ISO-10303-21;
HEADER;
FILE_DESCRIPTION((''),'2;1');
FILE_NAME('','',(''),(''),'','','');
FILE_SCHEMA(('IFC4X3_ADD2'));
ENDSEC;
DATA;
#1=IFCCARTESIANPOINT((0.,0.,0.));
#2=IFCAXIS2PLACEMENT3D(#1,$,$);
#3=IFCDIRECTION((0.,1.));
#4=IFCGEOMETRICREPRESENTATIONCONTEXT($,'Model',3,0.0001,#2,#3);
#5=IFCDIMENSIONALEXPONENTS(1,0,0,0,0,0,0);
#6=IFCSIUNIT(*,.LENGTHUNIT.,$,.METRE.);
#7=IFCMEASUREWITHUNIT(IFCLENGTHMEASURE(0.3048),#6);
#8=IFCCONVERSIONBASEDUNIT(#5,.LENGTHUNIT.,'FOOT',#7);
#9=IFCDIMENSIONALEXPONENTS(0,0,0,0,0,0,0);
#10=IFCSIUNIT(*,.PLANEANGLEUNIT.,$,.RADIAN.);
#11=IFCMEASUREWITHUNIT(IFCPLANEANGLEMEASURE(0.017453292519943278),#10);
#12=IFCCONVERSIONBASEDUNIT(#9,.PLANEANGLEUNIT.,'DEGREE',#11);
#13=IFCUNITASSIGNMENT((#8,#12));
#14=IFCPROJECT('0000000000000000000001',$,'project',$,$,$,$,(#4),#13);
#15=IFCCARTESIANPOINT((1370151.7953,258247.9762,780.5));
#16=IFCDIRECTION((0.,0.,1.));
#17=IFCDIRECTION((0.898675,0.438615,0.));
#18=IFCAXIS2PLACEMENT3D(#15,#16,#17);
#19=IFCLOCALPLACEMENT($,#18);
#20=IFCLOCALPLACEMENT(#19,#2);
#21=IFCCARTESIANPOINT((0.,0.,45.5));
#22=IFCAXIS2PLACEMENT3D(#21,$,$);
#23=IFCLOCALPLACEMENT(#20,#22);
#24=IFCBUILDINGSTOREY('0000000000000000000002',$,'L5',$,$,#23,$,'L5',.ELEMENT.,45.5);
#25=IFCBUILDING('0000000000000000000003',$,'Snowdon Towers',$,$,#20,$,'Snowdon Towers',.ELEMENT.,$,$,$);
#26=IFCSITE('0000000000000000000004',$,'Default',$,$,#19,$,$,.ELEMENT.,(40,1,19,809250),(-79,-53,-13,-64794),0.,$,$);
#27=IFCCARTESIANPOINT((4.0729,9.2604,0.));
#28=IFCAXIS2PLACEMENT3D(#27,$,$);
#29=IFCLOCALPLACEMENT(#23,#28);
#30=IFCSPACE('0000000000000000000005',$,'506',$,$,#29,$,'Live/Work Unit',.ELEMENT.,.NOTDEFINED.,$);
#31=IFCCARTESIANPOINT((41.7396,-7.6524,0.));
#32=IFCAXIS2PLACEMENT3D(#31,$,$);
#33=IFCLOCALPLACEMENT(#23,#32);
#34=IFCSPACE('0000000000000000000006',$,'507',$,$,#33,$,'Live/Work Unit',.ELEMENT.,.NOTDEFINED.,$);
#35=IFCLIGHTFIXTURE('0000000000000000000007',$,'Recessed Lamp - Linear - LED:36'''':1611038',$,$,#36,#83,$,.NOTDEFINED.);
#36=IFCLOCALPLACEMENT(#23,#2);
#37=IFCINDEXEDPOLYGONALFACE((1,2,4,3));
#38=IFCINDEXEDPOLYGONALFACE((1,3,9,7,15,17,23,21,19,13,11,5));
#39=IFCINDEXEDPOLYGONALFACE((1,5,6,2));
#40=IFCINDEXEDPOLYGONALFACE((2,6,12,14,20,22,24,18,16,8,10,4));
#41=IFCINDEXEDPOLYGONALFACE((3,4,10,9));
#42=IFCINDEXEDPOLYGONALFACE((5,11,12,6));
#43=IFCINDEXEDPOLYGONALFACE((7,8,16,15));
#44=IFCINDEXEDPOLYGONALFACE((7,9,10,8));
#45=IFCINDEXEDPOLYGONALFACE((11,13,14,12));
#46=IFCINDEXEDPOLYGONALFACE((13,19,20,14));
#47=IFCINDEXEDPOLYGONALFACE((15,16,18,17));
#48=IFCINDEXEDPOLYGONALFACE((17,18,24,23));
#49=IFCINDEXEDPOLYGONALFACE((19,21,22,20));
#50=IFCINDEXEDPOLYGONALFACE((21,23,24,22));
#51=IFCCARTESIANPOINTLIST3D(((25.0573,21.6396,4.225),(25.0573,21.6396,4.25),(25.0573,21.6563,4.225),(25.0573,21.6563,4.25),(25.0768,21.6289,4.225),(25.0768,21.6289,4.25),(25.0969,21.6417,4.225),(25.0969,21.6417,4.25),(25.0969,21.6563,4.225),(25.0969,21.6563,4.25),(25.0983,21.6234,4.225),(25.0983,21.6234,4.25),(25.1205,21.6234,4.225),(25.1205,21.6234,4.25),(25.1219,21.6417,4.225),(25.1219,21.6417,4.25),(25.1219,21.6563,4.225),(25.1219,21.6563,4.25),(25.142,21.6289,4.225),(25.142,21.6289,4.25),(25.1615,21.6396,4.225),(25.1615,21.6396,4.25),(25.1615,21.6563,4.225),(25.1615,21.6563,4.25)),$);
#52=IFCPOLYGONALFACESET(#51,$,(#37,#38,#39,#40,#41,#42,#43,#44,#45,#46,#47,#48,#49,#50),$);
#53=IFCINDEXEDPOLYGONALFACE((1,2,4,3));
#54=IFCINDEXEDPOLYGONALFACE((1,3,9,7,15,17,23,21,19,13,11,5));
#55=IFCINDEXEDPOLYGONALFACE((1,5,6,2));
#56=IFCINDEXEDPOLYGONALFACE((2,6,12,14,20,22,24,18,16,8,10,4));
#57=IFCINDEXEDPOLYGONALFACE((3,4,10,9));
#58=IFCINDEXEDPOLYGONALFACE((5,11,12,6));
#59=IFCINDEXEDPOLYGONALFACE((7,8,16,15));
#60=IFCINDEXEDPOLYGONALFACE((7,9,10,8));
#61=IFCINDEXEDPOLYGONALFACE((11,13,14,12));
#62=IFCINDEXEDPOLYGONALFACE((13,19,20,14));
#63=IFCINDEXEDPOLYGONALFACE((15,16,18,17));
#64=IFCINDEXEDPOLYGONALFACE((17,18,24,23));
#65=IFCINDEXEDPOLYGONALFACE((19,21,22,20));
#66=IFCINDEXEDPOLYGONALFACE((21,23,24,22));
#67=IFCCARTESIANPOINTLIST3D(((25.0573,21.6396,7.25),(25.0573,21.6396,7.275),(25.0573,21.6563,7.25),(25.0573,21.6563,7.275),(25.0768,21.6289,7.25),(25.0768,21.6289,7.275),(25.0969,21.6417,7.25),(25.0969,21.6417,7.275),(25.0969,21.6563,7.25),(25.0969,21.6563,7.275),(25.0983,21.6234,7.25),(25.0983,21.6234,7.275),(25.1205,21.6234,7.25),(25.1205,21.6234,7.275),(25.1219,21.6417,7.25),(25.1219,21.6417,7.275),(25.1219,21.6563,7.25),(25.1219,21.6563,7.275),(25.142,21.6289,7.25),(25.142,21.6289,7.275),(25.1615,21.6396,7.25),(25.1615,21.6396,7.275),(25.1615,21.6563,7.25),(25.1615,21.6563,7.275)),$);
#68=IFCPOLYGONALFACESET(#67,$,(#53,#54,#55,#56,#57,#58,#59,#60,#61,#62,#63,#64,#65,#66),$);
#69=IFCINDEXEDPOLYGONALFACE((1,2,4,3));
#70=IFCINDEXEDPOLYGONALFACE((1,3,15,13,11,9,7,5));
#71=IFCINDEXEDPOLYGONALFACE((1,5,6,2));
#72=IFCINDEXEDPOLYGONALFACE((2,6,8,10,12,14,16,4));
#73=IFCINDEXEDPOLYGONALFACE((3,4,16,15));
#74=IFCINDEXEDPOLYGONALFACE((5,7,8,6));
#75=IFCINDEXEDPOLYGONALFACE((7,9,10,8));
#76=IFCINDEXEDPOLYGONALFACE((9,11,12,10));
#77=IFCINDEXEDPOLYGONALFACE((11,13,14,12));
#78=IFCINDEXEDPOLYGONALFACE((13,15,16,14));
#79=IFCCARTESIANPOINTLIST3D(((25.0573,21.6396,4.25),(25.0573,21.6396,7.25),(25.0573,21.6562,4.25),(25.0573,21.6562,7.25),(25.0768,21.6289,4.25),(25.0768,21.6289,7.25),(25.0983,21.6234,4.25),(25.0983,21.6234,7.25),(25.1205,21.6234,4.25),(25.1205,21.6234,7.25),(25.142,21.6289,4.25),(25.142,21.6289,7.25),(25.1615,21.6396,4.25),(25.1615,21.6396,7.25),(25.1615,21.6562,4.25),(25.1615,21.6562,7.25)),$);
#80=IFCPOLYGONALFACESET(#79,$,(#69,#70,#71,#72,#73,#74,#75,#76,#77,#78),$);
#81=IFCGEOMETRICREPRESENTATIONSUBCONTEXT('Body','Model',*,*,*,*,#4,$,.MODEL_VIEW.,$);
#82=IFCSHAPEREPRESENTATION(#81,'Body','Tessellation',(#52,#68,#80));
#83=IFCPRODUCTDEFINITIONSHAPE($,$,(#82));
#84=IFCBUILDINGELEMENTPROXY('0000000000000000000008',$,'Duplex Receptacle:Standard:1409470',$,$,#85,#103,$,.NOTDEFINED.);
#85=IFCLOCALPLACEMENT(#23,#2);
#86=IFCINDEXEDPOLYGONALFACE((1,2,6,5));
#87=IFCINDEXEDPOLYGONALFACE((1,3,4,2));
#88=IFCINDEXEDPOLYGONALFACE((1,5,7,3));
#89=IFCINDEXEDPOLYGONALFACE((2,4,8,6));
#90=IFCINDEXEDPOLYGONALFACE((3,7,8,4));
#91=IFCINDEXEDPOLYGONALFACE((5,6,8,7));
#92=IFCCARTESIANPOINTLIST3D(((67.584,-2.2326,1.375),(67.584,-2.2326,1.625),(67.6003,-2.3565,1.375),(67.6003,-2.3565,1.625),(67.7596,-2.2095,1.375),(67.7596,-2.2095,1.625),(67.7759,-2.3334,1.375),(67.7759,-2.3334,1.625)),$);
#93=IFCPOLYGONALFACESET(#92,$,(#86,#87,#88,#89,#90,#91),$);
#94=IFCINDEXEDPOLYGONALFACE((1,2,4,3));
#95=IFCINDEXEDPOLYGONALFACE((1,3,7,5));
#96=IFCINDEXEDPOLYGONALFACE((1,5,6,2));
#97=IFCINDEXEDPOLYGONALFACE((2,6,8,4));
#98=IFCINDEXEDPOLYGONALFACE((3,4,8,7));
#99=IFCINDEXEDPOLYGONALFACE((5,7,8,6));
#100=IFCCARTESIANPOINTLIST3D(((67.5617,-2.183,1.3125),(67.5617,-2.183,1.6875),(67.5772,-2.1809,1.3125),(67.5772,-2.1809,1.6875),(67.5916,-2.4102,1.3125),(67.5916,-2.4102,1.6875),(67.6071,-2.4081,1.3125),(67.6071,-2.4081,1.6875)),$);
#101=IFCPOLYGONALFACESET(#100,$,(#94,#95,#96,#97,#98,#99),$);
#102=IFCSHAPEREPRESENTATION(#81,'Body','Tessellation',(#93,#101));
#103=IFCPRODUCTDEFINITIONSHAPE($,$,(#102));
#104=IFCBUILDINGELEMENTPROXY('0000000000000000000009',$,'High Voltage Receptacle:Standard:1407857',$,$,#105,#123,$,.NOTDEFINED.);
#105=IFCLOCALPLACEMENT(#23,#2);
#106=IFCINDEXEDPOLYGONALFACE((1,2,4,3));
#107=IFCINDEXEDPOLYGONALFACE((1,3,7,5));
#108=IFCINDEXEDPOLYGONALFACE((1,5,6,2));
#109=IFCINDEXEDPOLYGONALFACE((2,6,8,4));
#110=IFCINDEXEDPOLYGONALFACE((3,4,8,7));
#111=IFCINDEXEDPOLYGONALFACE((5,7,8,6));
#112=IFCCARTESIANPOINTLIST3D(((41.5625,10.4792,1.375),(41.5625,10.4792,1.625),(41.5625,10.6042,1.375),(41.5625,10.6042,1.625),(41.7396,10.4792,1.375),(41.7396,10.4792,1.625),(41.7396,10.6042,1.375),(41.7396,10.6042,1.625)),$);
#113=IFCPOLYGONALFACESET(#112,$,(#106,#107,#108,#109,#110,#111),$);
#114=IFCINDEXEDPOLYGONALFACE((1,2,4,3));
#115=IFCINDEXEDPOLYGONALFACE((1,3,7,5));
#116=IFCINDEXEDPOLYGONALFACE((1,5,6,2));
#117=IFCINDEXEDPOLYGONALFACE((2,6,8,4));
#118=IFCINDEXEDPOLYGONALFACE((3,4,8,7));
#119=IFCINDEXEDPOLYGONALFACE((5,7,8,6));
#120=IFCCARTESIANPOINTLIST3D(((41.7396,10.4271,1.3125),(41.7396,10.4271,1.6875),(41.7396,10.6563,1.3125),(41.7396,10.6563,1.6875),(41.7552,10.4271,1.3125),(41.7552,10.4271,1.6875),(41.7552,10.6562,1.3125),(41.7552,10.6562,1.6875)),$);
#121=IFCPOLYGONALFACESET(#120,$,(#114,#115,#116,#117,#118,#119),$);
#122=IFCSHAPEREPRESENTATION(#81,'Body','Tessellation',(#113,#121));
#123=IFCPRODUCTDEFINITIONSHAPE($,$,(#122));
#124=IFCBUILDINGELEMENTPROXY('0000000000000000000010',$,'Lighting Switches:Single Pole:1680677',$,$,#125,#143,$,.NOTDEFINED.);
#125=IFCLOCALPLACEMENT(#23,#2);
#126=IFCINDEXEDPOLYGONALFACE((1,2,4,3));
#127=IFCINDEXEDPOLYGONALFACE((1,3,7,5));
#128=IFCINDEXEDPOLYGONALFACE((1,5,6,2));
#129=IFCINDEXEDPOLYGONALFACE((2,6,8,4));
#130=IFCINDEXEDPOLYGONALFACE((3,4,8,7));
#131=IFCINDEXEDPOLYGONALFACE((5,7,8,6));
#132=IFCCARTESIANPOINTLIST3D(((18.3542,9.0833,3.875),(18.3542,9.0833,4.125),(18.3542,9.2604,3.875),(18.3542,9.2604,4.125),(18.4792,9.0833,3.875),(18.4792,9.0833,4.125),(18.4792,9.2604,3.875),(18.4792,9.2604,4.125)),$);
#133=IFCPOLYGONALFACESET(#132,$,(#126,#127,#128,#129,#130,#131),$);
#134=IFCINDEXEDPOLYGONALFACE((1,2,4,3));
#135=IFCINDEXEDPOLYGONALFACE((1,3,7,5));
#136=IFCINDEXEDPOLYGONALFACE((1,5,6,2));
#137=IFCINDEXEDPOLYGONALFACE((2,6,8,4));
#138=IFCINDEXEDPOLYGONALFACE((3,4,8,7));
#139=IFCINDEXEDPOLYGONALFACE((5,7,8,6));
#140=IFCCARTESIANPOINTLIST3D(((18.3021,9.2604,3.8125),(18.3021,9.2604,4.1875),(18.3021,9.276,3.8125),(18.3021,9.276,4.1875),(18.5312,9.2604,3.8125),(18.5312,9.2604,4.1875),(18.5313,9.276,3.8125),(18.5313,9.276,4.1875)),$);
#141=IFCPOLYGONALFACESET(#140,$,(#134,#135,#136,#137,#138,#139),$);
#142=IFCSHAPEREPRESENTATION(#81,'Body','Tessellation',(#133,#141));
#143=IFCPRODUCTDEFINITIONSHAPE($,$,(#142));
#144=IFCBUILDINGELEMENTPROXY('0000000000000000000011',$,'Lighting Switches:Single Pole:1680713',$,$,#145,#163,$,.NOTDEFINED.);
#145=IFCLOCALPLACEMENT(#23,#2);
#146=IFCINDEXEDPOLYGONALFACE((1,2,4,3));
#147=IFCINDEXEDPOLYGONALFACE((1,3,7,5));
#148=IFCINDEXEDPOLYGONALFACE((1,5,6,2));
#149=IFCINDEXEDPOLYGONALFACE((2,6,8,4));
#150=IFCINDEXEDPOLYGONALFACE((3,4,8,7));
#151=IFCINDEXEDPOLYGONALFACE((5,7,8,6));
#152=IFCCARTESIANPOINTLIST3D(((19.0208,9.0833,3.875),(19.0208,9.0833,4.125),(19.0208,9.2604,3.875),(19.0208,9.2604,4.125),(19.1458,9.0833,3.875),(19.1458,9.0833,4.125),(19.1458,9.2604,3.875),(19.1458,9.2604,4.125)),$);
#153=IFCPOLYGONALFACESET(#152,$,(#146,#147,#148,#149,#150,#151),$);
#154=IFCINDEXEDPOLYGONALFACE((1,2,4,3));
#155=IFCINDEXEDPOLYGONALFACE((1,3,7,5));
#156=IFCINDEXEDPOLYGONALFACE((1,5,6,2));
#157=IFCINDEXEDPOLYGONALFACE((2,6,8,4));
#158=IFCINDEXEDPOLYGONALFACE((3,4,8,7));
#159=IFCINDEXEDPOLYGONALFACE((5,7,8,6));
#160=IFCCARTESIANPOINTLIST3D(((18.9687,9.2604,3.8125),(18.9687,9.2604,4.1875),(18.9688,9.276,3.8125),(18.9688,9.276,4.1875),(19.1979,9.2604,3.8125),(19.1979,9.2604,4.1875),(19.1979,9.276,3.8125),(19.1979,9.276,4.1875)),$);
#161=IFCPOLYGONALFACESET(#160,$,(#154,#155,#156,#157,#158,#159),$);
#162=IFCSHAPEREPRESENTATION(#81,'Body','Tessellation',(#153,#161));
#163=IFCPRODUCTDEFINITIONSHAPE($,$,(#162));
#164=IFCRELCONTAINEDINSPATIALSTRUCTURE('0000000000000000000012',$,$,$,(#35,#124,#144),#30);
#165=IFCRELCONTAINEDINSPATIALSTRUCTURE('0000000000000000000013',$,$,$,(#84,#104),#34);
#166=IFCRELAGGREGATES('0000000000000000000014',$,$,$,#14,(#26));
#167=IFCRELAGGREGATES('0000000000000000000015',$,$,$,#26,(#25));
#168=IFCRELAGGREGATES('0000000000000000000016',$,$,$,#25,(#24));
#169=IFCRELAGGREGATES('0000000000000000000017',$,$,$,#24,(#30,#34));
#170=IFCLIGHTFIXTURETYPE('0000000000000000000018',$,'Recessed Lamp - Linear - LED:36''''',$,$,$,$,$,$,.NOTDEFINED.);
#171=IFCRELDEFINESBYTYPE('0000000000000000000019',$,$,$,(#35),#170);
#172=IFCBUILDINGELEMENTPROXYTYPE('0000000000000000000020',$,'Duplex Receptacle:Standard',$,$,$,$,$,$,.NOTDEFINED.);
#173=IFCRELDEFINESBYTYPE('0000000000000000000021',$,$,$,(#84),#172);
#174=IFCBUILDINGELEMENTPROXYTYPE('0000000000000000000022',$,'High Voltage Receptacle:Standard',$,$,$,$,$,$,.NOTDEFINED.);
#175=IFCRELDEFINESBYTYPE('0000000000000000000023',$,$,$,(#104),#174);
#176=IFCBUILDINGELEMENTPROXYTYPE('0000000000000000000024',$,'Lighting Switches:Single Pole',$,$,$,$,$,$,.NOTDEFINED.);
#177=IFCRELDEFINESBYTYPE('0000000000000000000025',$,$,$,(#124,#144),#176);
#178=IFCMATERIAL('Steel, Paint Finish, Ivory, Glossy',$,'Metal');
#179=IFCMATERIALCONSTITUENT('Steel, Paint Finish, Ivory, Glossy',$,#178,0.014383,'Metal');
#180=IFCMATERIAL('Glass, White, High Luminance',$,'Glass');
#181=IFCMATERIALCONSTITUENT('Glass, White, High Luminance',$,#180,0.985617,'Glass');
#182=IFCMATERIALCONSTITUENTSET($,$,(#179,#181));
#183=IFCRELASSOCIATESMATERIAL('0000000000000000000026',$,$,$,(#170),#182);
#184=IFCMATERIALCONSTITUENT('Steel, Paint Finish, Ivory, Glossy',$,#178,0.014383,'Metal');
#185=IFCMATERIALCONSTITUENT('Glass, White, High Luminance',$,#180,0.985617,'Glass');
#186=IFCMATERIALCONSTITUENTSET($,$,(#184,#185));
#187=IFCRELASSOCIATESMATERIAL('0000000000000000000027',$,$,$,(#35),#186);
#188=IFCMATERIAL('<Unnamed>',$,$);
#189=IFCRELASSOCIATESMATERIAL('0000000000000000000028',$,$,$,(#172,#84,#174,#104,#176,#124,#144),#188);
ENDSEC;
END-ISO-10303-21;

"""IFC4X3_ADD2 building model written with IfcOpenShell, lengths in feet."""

from ifc_helpers import new_model, entity, si_unit, converted_unit, direction, frame, frame_2d, origin, origin_2d_with_axis, place, context, subcontext, project, spatial, polyline, circle_curve, parameter, trimmed, segment, composite_curve, rectangle, outline, extrude, source, transform, mapped, material, constituent, constituent_set, type_object, type_shapes, element, save


model = new_model("IFC4X3_ADD2")

# Units and contexts
model_context = context("Model", 3, precision=0.0001, world=origin(), true_north=direction((0.0, 1.0)))
body_context = subcontext(model_context, "Body", "Model", "MODEL_VIEW")
ifc_project = project(units=[converted_unit("LENGTHUNIT", "FOOT", entity("IfcLengthMeasure", 0.3048), si_unit("LENGTHUNIT", "METRE"), dimensions=[1, 0, 0, 0, 0, 0, 0]), converted_unit("PLANEANGLEUNIT", "DEGREE", entity("IfcPlaneAngleMeasure", 0.017453292519943278), si_unit("PLANEANGLEUNIT", "RADIAN"), dimensions=[0, 0, 0, 0, 0, 0, 0])], contexts=[model_context])

# Site, building, storey, space
site_placement = place(None, frame((1370151.7953, 258247.9762, 780.5), z_axis=(0.0, 0.0, 1.0), x_axis=(0.898675, 0.438615, 0.0)))
site = spatial("IfcSite", under=ifc_project, at=site_placement, Name="Default", CompositionType="ELEMENT", RefLatitude=(40, 1, 19, 809250), RefLongitude=(-79, -53, -13, -64794), RefElevation=0.0)
building_placement = place(site_placement, origin())
building = spatial("IfcBuilding", under=site, at=building_placement, Name="Snowdon Towers", LongName="Snowdon Towers", CompositionType="ELEMENT")
storey_placement = place(building_placement, frame((0.0, 0.0, 45.5)))
storey = spatial("IfcBuildingStorey", under=building, at=storey_placement, Name="L5", LongName="L5", CompositionType="ELEMENT", Elevation=45.5)
space_1_placement = place(storey_placement, frame((4.0729, 9.2604, 0.0)))
space_1 = spatial("IfcSpace", under=storey, at=space_1_placement, Name="506", LongName="Live/Work Unit", CompositionType="ELEMENT", PredefinedType="NOTDEFINED")

# Shared definitions
ifc_material_1 = material(Name="<Unnamed>")

# Shared definitions
ifc_material_2 = material(Name="Glass, White, High Luminance", Category="Glass")
ifc_material_3 = material(Name="Steel, Paint Finish, Ivory, Glossy", Category="Metal")
ifc_constituent_1 = constituent(ifc_material_3, Name="Steel, Paint Finish, Ivory, Glossy", Category="Metal", fraction=0.014383)
ifc_constituent_2 = constituent(ifc_material_2, Name="Glass, White, High Luminance", Category="Glass", fraction=0.985617)
ifc_constituent_set_1 = constituent_set(constituents=[ifc_constituent_1, ifc_constituent_2])
light_fixture_type_1 = type_object("IfcLightFixtureType", Name="Recessed Lamp - Linear - LED:36''", PredefinedType="NOTDEFINED", material=ifc_constituent_set_1)
shared_shape_1 = source(origin(), body_context, "Body", "SweptSolid", [
    extrude(outline(composite_curve([segment(trimmed(circle_curve(frame_2d((0.0, -0.0633), x_axis=(1.0, 0.0)), 0.089), [parameter(54.196986)], [parameter(125.803014)], True, "PARAMETER"), True, "CONTINUOUS"), segment(polyline([(-0.0521, 0.0089), (-0.0521, -0.0078)]), True, "CONTINUOUS"), segment(polyline([(-0.0521, -0.0078), (-0.0125, -0.0078)]), True, "CONTINUOUS"), segment(polyline([(-0.0125, -0.0078), (-0.0125, 0.0068)]), True, "CONTINUOUS"), segment(polyline([(-0.0125, 0.0068), (0.0125, 0.0068)]), True, "CONTINUOUS"), segment(polyline([(0.0125, 0.0068), (0.0125, -0.0078)]), True, "CONTINUOUS"), segment(polyline([(0.0125, -0.0078), (0.0521, -0.0078)]), True, "CONTINUOUS"), segment(polyline([(0.0521, -0.0078), (0.0521, 0.0089)]), True, "CONTINUOUS")], self_intersect=False)), frame((-1.525, 0.0, 0.0078), z_axis=(1.0, 0.0, 0.0), x_axis=(0.0, 1.0, 0.0)), (0.0, 0.0, 1.0), 0.025),
    extrude(outline(composite_curve([segment(trimmed(circle_curve(frame_2d((0.0, -0.0633), x_axis=(1.0, 0.0)), 0.089), [parameter(54.196986)], [parameter(125.803014)], True, "PARAMETER"), True, "CONTINUOUS"), segment(polyline([(-0.0521, 0.0089), (-0.0521, -0.0078)]), True, "CONTINUOUS"), segment(polyline([(-0.0521, -0.0078), (-0.0125, -0.0078)]), True, "CONTINUOUS"), segment(polyline([(-0.0125, -0.0078), (-0.0125, 0.0068)]), True, "CONTINUOUS"), segment(polyline([(-0.0125, 0.0068), (0.0125, 0.0068)]), True, "CONTINUOUS"), segment(polyline([(0.0125, 0.0068), (0.0125, -0.0078)]), True, "CONTINUOUS"), segment(polyline([(0.0125, -0.0078), (0.0521, -0.0078)]), True, "CONTINUOUS"), segment(polyline([(0.0521, -0.0078), (0.0521, 0.0089)]), True, "CONTINUOUS")], self_intersect=False)), frame((1.5, 0.0, 0.0078), z_axis=(1.0, 0.0, 0.0), x_axis=(0.0, 1.0, 0.0)), (0.0, 0.0, 1.0), 0.025),
    extrude(outline(composite_curve([segment(trimmed(circle_curve(frame_2d((0.0, -0.0639), x_axis=(1.0, 0.0)), 0.089), [parameter(54.196986)], [parameter(125.803014)], True, "PARAMETER"), True, "CONTINUOUS"), segment(polyline([(-0.0521, 0.0083), (-0.0521, -0.0083)]), True, "CONTINUOUS"), segment(polyline([(-0.0521, -0.0083), (0.0521, -0.0083)]), True, "CONTINUOUS"), segment(polyline([(0.0521, -0.0083), (0.0521, 0.0083)]), True, "CONTINUOUS")], self_intersect=False)), frame((-1.5, 0.0, 0.0083), z_axis=(1.0, 0.0, 0.0), x_axis=(0.0, 1.0, 0.0)), (0.0, 0.0, 1.0), 3.0),
])
type_shapes(light_fixture_type_1, [shared_shape_1])

# Shared definitions
space_2_placement = place(storey_placement, frame((41.7396, -7.6524, 0.0)))
space_2 = spatial("IfcSpace", under=storey, at=space_2_placement, Name="507", LongName="Live/Work Unit", CompositionType="ELEMENT", PredefinedType="NOTDEFINED")

# Light fixture
ifc_constituent_3 = constituent(ifc_material_3, Name="Steel, Paint Finish, Ivory, Glossy", Category="Metal", fraction=0.014383)
ifc_constituent_4 = constituent(ifc_material_2, Name="Glass, White, High Luminance", Category="Glass", fraction=0.985617)
ifc_constituent_set_2 = constituent_set(constituents=[ifc_constituent_3, ifc_constituent_4])
light_fixture_1_placement = place(space_1_placement, frame((21.0365, 12.3958, 5.75), z_axis=(0.0, -1.0, 0.0), x_axis=(0.0, 0.0, 1.0)))
element("IfcLightFixture", 1, at=light_fixture_1_placement, inside=space_1, type_object=light_fixture_type_1, material=ifc_constituent_set_2, Name="Recessed Lamp - Linear - LED:36'':1611038", PredefinedType="NOTDEFINED", context=body_context, shape_type="MappedRepresentation", body=[
    mapped(shared_shape_1, transform((0.0, 0.0, 0.0), scale=1.0)),
])

# Building element proxy
building_element_proxy_type_1 = type_object("IfcBuildingElementProxyType", Name="Duplex Receptacle:Standard", PredefinedType="NOTDEFINED", material=ifc_material_1)
shared_shape_2 = source(origin(), body_context, "Body", "SweptSolid", [
    extrude(rectangle(XDim=0.125, YDim=0.25, at=origin_2d_with_axis()), frame((0.0, 0.0, -0.1771), z_axis=(0.0, 0.0, 1.0), x_axis=(-1.0, 0.0, 0.0)), (0.0, 0.0, 1.0), 0.1771),
    extrude(rectangle(XDim=0.2292, YDim=0.375, at=frame_2d((0.0, 0.0), x_axis=(1.0, 0.0))), frame((0.0, 0.0, 0.0), z_axis=(0.0, 0.0, 1.0), x_axis=(-1.0, 0.0, 0.0)), (0.0, 0.0, 1.0), 0.0156),
])
type_shapes(building_element_proxy_type_1, [shared_shape_2])
for number, where, z_axis, x_axis, name in (
    (2, (25.8526, 5.3578, 1.5), (-0.991445, -0.130526, 0.0), (0.130526, -0.991445, 0.0), "Duplex Receptacle:Standard:1409470"),
):
    element("IfcBuildingElementProxy", number, at=place(space_2_placement, frame(where, z_axis=z_axis, x_axis=x_axis)), inside=space_2, type_object=building_element_proxy_type_1, material=ifc_material_1, Name=name, PredefinedType="NOTDEFINED", context=body_context, shape_type="MappedRepresentation", body=[
        mapped(shared_shape_2, transform((0.0, 0.0, 0.0), scale=1.0)),
    ])

# Building element proxies
building_element_proxy_type_2 = type_object("IfcBuildingElementProxyType", Name="High Voltage Receptacle:Standard", PredefinedType="NOTDEFINED", material=ifc_material_1)
shared_shape_3 = source(origin(), body_context, "Body", "SweptSolid", [
    extrude(rectangle(XDim=0.125, YDim=0.25, at=origin_2d_with_axis()), frame((0.0, 0.0, -0.1771), z_axis=(0.0, 0.0, 1.0), x_axis=(-1.0, 0.0, 0.0)), (0.0, 0.0, 1.0), 0.1771),
    extrude(rectangle(XDim=0.2292, YDim=0.375, at=frame_2d((0.0, 0.0), x_axis=(1.0, 0.0))), frame((0.0, 0.0, 0.0), z_axis=(0.0, 0.0, 1.0), x_axis=(-1.0, 0.0, 0.0)), (0.0, 0.0, 1.0), 0.0156),
])
type_shapes(building_element_proxy_type_2, [shared_shape_3])
proxy_1_placement = place(space_2_placement, frame((0.0, 18.194, 1.5), z_axis=(1.0, 0.0, 0.0), x_axis=(0.0, 1.0, 0.0)))
element("IfcBuildingElementProxy", 3, at=proxy_1_placement, inside=space_2, type_object=building_element_proxy_type_2, material=ifc_material_1, Name="High Voltage Receptacle:Standard:1407857", PredefinedType="NOTDEFINED", context=body_context, shape_type="MappedRepresentation", body=[
    mapped(shared_shape_3, transform((0.0, 0.0, 0.0), scale=1.0)),
])
building_element_proxy_type_3 = type_object("IfcBuildingElementProxyType", Name="Lighting Switches:Single Pole", PredefinedType="NOTDEFINED", material=ifc_material_1)
shared_shape_4 = source(origin(), body_context, "Body", "SweptSolid", [
    extrude(rectangle(XDim=0.125, YDim=0.25, at=origin_2d_with_axis()), frame((0.0, 0.0, -0.1771), z_axis=(0.0, 0.0, 1.0), x_axis=(-1.0, 0.0, 0.0)), (0.0, 0.0, 1.0), 0.1771),
    extrude(rectangle(XDim=0.2292, YDim=0.375, at=frame_2d((0.0, 0.0), x_axis=(1.0, 0.0))), frame((0.0, 0.0, 0.0), z_axis=(0.0, 0.0, 1.0), x_axis=(-1.0, 0.0, 0.0)), (0.0, 0.0, 1.0), 0.0156),
])
type_shapes(building_element_proxy_type_3, [shared_shape_4])
for number, where, z_axis, x_axis, name in (
    (4, (14.3438, 0.0, 4.0), (0.0, 1.0, 0.0), (-1.0, 0.0, 0.0), "Lighting Switches:Single Pole:1680677"),
    (5, (15.0104, 0.0, 4.0), (0.0, 1.0, 0.0), (-1.0, 0.0, 0.0), "Lighting Switches:Single Pole:1680713"),
):
    element("IfcBuildingElementProxy", number, at=place(space_1_placement, frame(where, z_axis=z_axis, x_axis=x_axis)), inside=space_1, type_object=building_element_proxy_type_3, material=ifc_material_1, Name=name, PredefinedType="NOTDEFINED", context=body_context, shape_type="MappedRepresentation", body=[
        mapped(shared_shape_4, transform((0.0, 0.0, 0.0), scale=1.0)),
    ])

save(model, "model.ifc")
